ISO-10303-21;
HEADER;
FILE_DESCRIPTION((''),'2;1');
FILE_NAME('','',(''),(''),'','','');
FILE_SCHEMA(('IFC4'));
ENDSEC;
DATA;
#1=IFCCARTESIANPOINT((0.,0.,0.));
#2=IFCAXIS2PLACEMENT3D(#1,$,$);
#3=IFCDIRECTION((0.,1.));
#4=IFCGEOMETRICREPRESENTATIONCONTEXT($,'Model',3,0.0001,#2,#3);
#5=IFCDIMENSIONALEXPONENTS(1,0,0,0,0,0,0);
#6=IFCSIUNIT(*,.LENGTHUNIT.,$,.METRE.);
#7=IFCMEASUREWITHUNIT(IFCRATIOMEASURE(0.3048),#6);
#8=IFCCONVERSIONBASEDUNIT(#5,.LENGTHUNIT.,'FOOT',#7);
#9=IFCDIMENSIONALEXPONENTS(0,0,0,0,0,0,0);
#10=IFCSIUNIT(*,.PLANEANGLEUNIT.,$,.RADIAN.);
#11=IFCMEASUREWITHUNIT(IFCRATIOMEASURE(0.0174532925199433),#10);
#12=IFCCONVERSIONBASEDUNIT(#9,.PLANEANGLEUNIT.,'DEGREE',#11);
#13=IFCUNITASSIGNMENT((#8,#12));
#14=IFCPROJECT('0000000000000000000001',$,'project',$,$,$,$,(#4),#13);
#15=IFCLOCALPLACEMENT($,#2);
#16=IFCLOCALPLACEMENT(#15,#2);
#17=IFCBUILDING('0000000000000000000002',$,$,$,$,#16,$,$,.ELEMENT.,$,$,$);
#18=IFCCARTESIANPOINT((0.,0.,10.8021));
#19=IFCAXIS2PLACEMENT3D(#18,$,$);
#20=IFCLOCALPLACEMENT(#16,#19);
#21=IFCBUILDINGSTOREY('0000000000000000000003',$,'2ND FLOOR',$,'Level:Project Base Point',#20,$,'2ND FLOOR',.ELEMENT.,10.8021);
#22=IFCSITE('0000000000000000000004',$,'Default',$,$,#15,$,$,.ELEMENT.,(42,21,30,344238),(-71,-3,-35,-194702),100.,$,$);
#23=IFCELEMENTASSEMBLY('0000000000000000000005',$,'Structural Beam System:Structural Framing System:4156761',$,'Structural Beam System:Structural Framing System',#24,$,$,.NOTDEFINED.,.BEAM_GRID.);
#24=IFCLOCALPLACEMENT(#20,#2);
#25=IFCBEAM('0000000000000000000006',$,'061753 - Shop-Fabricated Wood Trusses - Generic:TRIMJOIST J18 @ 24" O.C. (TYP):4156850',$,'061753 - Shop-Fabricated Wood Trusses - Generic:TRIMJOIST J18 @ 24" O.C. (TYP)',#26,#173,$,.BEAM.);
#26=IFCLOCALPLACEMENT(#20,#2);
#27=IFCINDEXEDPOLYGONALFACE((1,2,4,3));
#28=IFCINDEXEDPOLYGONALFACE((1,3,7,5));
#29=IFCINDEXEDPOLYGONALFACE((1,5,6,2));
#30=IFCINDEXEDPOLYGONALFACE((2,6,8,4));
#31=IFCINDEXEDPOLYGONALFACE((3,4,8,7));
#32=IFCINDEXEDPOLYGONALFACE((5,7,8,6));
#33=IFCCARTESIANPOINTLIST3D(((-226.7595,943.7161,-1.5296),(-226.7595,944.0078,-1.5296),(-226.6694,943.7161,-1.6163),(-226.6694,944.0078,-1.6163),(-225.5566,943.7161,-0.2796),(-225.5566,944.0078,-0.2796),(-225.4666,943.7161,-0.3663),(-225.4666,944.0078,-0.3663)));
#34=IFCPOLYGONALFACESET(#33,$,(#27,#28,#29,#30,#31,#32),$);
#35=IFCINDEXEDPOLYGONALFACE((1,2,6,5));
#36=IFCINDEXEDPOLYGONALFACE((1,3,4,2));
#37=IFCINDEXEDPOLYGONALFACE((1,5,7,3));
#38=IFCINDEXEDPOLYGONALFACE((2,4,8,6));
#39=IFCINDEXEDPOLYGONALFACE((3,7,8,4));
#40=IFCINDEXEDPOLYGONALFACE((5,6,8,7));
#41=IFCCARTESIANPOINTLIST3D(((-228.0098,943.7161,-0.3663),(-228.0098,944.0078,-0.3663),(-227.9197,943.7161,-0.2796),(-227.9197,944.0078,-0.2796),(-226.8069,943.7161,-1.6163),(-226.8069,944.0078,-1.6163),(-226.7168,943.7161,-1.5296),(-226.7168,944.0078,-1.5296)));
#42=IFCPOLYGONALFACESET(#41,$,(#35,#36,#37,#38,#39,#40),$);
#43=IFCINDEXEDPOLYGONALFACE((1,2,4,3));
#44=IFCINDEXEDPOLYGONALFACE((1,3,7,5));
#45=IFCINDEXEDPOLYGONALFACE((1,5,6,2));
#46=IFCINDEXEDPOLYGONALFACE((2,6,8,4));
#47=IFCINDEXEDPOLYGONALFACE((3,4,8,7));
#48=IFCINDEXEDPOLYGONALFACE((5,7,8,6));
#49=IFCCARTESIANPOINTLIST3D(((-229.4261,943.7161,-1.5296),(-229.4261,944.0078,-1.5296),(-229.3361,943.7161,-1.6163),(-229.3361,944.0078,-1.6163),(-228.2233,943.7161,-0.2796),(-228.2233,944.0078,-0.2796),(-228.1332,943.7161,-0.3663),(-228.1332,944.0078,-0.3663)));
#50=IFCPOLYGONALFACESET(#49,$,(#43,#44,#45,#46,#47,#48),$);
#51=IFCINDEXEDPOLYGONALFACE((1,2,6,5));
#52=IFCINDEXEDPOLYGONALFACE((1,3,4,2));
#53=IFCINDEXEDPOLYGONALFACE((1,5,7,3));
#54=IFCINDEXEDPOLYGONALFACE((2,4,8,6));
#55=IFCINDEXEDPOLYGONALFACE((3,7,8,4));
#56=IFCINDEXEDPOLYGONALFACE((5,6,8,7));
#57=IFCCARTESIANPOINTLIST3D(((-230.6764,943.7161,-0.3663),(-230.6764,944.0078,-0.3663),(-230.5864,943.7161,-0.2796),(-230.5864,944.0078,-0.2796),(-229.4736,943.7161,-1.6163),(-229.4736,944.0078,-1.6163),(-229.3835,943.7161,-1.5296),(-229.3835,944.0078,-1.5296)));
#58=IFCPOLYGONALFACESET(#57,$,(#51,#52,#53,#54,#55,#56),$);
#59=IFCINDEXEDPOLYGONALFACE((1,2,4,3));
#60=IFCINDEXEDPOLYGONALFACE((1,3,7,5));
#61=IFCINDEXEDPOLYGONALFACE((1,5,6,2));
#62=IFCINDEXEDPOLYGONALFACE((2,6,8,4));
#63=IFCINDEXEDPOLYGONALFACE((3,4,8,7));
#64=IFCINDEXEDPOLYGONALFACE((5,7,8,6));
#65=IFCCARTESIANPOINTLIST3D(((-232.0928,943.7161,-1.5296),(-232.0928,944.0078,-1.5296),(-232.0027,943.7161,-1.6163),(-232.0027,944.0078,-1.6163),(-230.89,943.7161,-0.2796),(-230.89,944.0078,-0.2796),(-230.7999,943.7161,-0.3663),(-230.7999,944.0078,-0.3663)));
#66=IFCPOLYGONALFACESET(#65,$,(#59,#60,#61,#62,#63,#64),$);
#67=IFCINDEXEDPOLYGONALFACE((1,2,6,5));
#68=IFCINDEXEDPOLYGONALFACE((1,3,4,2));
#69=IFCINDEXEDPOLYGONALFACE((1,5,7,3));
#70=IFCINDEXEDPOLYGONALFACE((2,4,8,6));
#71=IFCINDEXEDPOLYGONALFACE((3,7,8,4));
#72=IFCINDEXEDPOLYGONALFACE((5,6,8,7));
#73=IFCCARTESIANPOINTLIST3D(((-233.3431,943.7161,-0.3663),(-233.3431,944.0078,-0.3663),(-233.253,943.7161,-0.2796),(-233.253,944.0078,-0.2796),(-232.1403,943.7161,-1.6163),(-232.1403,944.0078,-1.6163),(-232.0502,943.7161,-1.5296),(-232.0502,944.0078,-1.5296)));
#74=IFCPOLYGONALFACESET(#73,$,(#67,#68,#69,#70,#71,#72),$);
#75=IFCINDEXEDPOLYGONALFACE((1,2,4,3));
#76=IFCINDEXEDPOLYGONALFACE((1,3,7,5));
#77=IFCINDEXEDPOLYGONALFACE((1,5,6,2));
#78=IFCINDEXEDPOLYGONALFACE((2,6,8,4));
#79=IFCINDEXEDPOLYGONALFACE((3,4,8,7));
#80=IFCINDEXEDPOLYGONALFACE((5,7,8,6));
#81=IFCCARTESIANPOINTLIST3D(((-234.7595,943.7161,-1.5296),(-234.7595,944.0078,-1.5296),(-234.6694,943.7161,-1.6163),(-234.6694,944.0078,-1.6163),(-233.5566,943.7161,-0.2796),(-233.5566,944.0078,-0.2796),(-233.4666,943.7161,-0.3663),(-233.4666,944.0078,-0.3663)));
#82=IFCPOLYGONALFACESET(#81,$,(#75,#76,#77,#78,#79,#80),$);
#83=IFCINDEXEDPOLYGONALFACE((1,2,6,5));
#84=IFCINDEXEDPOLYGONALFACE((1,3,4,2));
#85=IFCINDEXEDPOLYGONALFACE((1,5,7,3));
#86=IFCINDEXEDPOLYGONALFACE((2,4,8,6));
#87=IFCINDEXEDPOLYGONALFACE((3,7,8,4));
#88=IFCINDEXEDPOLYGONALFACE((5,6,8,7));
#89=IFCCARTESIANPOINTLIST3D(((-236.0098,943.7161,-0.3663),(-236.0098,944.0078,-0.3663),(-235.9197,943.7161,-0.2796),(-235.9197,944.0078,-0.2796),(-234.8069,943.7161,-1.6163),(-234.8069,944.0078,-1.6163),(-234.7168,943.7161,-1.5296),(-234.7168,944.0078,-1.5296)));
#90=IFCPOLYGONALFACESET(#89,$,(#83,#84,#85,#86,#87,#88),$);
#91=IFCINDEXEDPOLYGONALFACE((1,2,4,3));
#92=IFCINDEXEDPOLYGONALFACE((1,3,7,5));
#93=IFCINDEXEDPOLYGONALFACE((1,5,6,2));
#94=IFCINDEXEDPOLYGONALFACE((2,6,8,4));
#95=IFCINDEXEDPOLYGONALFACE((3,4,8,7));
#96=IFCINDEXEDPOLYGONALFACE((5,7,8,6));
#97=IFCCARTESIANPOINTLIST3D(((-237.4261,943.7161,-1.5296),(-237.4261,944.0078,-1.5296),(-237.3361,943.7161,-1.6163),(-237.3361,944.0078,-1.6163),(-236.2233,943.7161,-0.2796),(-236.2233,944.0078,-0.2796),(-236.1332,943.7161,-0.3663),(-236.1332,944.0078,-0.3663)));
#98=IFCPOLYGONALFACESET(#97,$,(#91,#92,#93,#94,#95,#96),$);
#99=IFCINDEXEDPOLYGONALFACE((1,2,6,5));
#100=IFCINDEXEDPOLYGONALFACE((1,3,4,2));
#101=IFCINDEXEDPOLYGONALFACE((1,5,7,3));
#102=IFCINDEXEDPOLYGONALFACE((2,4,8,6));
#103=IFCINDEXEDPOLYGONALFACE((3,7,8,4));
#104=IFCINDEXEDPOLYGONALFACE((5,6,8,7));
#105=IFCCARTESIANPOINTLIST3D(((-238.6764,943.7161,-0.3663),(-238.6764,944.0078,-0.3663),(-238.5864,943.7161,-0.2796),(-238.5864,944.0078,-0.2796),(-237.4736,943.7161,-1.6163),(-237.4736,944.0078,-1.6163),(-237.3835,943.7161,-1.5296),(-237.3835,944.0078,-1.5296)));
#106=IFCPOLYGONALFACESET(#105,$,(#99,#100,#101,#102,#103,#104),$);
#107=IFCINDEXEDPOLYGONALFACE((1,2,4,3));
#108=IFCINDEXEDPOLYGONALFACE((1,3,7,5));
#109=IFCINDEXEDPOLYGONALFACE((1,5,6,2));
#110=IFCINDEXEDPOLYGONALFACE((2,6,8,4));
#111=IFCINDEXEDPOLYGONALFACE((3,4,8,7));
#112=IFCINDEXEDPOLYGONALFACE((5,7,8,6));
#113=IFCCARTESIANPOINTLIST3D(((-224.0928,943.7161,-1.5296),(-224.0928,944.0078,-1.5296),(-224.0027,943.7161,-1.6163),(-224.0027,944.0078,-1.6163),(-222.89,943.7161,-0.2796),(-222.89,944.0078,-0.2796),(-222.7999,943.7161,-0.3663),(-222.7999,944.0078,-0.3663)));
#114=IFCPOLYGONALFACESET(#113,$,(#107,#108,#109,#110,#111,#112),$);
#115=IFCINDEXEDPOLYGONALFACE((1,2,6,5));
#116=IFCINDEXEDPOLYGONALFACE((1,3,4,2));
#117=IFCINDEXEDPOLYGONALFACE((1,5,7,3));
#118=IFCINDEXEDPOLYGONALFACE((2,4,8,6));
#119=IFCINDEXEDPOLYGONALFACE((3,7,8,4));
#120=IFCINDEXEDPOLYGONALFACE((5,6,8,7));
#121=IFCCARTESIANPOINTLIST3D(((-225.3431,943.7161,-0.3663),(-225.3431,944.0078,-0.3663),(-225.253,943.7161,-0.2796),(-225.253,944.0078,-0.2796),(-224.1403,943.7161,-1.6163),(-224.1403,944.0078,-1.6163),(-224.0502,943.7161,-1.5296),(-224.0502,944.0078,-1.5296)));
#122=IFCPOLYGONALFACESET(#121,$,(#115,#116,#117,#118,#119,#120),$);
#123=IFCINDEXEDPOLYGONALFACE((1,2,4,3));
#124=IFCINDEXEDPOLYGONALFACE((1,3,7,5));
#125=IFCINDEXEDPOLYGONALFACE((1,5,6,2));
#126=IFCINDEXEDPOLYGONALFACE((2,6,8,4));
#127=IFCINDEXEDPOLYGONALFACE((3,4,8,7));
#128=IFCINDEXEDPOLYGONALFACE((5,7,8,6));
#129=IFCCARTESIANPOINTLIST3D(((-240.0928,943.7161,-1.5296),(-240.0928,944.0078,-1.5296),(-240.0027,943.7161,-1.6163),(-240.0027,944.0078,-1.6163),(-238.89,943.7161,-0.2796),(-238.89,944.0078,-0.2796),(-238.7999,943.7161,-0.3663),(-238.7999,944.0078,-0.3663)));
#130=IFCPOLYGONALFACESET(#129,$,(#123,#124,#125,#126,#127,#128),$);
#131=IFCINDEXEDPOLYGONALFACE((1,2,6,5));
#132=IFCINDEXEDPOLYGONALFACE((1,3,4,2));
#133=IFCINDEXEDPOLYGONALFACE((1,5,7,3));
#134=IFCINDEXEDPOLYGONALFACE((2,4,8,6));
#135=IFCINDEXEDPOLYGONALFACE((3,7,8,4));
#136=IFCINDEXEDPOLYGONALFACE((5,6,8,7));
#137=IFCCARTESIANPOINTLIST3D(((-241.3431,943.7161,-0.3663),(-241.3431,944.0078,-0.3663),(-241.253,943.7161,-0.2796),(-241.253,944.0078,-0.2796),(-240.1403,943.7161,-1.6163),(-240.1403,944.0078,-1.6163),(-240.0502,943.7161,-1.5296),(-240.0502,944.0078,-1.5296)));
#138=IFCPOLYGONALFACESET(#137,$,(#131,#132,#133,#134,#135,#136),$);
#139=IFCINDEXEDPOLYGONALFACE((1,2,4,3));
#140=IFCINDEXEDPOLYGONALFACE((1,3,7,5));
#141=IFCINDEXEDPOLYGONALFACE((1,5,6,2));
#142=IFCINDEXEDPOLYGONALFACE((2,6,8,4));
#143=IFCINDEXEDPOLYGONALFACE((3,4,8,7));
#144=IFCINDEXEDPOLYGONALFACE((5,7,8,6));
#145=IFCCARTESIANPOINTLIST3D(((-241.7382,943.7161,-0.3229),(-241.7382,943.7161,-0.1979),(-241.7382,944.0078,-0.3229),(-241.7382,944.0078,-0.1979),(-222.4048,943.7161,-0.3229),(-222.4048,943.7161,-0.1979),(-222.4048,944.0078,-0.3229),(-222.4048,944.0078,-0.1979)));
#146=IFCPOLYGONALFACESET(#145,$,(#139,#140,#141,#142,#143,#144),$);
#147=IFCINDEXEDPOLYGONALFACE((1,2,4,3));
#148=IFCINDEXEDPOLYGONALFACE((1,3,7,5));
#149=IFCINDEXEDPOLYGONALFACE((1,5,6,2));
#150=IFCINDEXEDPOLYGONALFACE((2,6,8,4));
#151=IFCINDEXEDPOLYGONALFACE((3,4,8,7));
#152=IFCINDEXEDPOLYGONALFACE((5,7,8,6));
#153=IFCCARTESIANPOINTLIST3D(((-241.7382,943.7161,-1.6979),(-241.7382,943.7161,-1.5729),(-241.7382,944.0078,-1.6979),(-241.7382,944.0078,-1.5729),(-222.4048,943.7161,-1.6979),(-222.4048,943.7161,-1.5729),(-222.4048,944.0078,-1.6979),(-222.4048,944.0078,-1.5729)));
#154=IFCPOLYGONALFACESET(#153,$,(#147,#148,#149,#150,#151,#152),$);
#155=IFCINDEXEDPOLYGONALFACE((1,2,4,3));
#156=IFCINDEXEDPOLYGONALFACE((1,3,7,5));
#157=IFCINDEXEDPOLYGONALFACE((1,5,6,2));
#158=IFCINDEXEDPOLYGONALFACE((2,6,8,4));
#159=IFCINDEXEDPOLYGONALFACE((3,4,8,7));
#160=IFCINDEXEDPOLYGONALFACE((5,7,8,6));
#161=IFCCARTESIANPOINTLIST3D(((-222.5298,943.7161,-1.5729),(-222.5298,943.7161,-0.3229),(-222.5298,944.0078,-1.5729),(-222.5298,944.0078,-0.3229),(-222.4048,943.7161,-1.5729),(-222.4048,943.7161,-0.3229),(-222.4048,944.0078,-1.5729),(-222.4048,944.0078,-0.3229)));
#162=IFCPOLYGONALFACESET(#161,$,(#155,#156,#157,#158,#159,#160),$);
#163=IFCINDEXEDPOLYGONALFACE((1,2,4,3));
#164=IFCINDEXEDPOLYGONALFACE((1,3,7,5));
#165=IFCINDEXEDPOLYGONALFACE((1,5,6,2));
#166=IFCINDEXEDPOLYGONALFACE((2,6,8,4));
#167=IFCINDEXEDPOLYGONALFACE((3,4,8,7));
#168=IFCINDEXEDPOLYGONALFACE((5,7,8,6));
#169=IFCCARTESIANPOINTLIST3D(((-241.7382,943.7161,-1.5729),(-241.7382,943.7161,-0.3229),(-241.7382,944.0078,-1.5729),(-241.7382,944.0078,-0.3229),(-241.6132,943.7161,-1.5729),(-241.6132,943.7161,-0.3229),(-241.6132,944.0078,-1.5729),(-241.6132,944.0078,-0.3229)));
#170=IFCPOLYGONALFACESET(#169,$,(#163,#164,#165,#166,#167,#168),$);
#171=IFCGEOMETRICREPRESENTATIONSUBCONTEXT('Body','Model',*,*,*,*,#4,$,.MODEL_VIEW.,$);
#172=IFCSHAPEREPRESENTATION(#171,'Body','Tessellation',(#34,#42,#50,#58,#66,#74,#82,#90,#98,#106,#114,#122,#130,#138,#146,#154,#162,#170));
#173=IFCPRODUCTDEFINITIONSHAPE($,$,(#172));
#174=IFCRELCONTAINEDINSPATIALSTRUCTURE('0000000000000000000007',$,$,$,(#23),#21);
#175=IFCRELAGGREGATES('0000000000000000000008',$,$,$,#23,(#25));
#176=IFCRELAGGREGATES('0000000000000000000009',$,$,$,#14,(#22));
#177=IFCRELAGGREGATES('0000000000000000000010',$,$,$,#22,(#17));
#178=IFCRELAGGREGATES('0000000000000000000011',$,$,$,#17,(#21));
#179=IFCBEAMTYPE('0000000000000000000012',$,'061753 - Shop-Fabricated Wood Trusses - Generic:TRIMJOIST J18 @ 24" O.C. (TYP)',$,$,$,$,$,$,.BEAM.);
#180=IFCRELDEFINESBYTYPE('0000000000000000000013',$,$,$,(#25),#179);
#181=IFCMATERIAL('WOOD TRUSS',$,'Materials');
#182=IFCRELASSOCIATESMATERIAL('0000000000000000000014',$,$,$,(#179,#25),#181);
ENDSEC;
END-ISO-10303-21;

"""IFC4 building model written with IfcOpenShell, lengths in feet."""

from ifc_helpers import new_model, entity, si_unit, converted_unit, direction, frame, frame_2d, origin, origin_2d_with_axis, place, context, subcontext, project, spatial, rectangle, extrude, source, transform, mapped, material, material_profile, profile_set, profile_usage, type_object, type_shapes, element, aggregate, save


model = new_model("IFC4")

# Units and contexts
model_context = context("Model", 3, precision=0.0001, world=origin(), true_north=direction((0.0, 1.0)))
body_context = subcontext(model_context, "Body", "Model", "MODEL_VIEW")
ifc_project = project(units=[converted_unit("LENGTHUNIT", "FOOT", entity("IfcRatioMeasure", 0.3048), si_unit("LENGTHUNIT", "METRE"), dimensions=[1, 0, 0, 0, 0, 0, 0]), converted_unit("PLANEANGLEUNIT", "DEGREE", entity("IfcRatioMeasure", 0.0174532925199433), si_unit("PLANEANGLEUNIT", "RADIAN"), dimensions=[0, 0, 0, 0, 0, 0, 0])], contexts=[model_context])

# Site, building, storey
site_placement = place(None, origin())
site = spatial("IfcSite", under=ifc_project, at=site_placement, Name="Default", CompositionType="ELEMENT", RefLatitude=(42, 21, 30, 344238), RefLongitude=(-71, -3, -35, -194702), RefElevation=100.0)
building_placement = place(site_placement, origin())
building = spatial("IfcBuilding", under=site, at=building_placement, CompositionType="ELEMENT")
storey_placement = place(building_placement, frame((0.0, 0.0, 10.8021)))
storey = spatial("IfcBuildingStorey", under=building, at=storey_placement, Name="2ND FLOOR", ObjectType="Level:Project Base Point", LongName="2ND FLOOR", CompositionType="ELEMENT", Elevation=10.8021)

# Element assembly, beam
assembly_1_placement = place(storey_placement, origin())
assembly_1 = element("IfcElementAssembly", 1, at=assembly_1_placement, inside=storey, Name="Structural Beam System:Structural Framing System:4156761", ObjectType="Structural Beam System:Structural Framing System", AssemblyPlace="NOTDEFINED", PredefinedType="BEAM_GRID")
ifc_material_1 = material(Name="WOOD TRUSS", Category="Materials")
ifc_material_profile_1 = material_profile(ifc_material_1, rectangle(XDim=1.7347, YDim=0.125, at=frame_2d((0.0, 0.0), x_axis=(1.0, 0.0))), Name="TRIMJOIST J18 @ 24\" O.C. (TYP)")
ifc_material_profile_2 = material_profile(ifc_material_1, rectangle(XDim=1.7347, YDim=0.125, at=frame_2d((0.0, 0.0), x_axis=(1.0, 0.0))), Name="TRIMJOIST J18 @ 24\" O.C. (TYP)")
ifc_material_profile_3 = material_profile(ifc_material_1, rectangle(XDim=1.7347, YDim=0.125, at=frame_2d((0.0, 0.0), x_axis=(1.0, 0.0))), Name="TRIMJOIST J18 @ 24\" O.C. (TYP)")
ifc_material_profile_4 = material_profile(ifc_material_1, rectangle(XDim=1.7347, YDim=0.125, at=frame_2d((0.0, 0.0), x_axis=(1.0, 0.0))), Name="TRIMJOIST J18 @ 24\" O.C. (TYP)")
ifc_material_profile_5 = material_profile(ifc_material_1, rectangle(XDim=1.7347, YDim=0.125, at=frame_2d((0.0, 0.0), x_axis=(1.0, 0.0))), Name="TRIMJOIST J18 @ 24\" O.C. (TYP)")
ifc_material_profile_6 = material_profile(ifc_material_1, rectangle(XDim=1.7347, YDim=0.125, at=frame_2d((0.0, 0.0), x_axis=(1.0, 0.0))), Name="TRIMJOIST J18 @ 24\" O.C. (TYP)")
ifc_material_profile_7 = material_profile(ifc_material_1, rectangle(XDim=1.7347, YDim=0.125, at=frame_2d((0.0, 0.0), x_axis=(1.0, 0.0))), Name="TRIMJOIST J18 @ 24\" O.C. (TYP)")
ifc_material_profile_8 = material_profile(ifc_material_1, rectangle(XDim=1.7347, YDim=0.125, at=frame_2d((0.0, 0.0), x_axis=(1.0, 0.0))), Name="TRIMJOIST J18 @ 24\" O.C. (TYP)")
ifc_material_profile_9 = material_profile(ifc_material_1, rectangle(XDim=1.7347, YDim=0.125, at=frame_2d((0.0, 0.0), x_axis=(1.0, 0.0))), Name="TRIMJOIST J18 @ 24\" O.C. (TYP)")
ifc_material_profile_10 = material_profile(ifc_material_1, rectangle(XDim=1.7347, YDim=0.125, at=origin_2d_with_axis()), Name="TRIMJOIST J18 @ 24\" O.C. (TYP)")
ifc_material_profile_11 = material_profile(ifc_material_1, rectangle(XDim=0.125, YDim=0.2917, at=origin_2d_with_axis()), Name="TRIMJOIST J18 @ 24\" O.C. (TYP)")
ifc_material_profile_12 = material_profile(ifc_material_1, rectangle(XDim=0.125, YDim=0.2917, at=origin_2d_with_axis()), Name="TRIMJOIST J18 @ 24\" O.C. (TYP)")
ifc_material_profile_13 = material_profile(ifc_material_1, rectangle(XDim=1.25, YDim=0.2917, at=origin_2d_with_axis()), Name="TRIMJOIST J18 @ 24\" O.C. (TYP)")
ifc_material_profile_14 = material_profile(ifc_material_1, rectangle(XDim=1.25, YDim=0.2917, at=origin_2d_with_axis()), Name="TRIMJOIST J18 @ 24\" O.C. (TYP)")
ifc_profile_set_1 = profile_set([ifc_material_profile_1, ifc_material_profile_2, ifc_material_profile_3, ifc_material_profile_4, ifc_material_profile_5, ifc_material_profile_6, ifc_material_profile_7, ifc_material_profile_8, ifc_material_profile_9, ifc_material_profile_10, ifc_material_profile_11, ifc_material_profile_12, ifc_material_profile_13, ifc_material_profile_14], Name="TRIMJOIST J18 @ 24\" O.C. (TYP)")
beam_type_1 = type_object("IfcBeamType", Name="061753 - Shop-Fabricated Wood Trusses - Generic:TRIMJOIST J18 @ 24\" O.C. (TYP)", PredefinedType="BEAM", material=ifc_profile_set_1)
shared_shape_1 = source(origin(), body_context, "Body", "SweptSolid", [
    extrude(rectangle(XDim=1.7347, YDim=0.125, at=frame_2d((0.0, 0.0), x_axis=(1.0, 0.0))), frame((5.9585, -0.1458, 0.0), z_axis=(0.0, 1.0, 0.0), x_axis=(0.693383, 0.0, 0.720569)), (0.0, 0.0, 1.0), 0.2917),
    extrude(rectangle(XDim=1.7347, YDim=0.125, at=origin_2d_with_axis()), frame((4.7082, -0.1458, 0.0), z_axis=(0.0, 1.0, 0.0), x_axis=(0.693383, 0.0, -0.720569)), (0.0, 0.0, 1.0), 0.2917),
    extrude(rectangle(XDim=1.7347, YDim=0.125, at=frame_2d((0.0, 0.0), x_axis=(1.0, 0.0))), frame((3.2918, -0.1458, 0.0), z_axis=(0.0, 1.0, 0.0), x_axis=(0.693383, 0.0, 0.720569)), (0.0, 0.0, 1.0), 0.2917),
    extrude(rectangle(XDim=1.7347, YDim=0.125, at=frame_2d((0.0, 0.0), x_axis=(1.0, 0.0))), frame((2.0415, -0.1458, 0.0), z_axis=(0.0, 1.0, 0.0), x_axis=(0.693383, 0.0, -0.720569)), (0.0, 0.0, 1.0), 0.2917),
    extrude(rectangle(XDim=1.7347, YDim=0.125, at=frame_2d((0.0, 0.0), x_axis=(1.0, 0.0))), frame((0.6251, -0.1458, 0.0), z_axis=(0.0, 1.0, 0.0), x_axis=(0.693383, 0.0, 0.720569)), (0.0, 0.0, 1.0), 0.2917),
    extrude(rectangle(XDim=1.7347, YDim=0.125, at=frame_2d((0.0, 0.0), x_axis=(1.0, 0.0))), frame((-0.6251, -0.1458, 0.0), z_axis=(0.0, 1.0, 0.0), x_axis=(0.693383, 0.0, -0.720569)), (0.0, 0.0, 1.0), 0.2917),
    extrude(rectangle(XDim=1.7347, YDim=0.125, at=frame_2d((0.0, 0.0), x_axis=(1.0, 0.0))), frame((-2.0415, -0.1458, 0.0), z_axis=(0.0, 1.0, 0.0), x_axis=(0.693383, 0.0, 0.720569)), (0.0, 0.0, 1.0), 0.2917),
    extrude(rectangle(XDim=1.7347, YDim=0.125, at=origin_2d_with_axis()), frame((-3.2918, -0.1458, 0.0), z_axis=(0.0, 1.0, 0.0), x_axis=(0.693383, 0.0, -0.720569)), (0.0, 0.0, 1.0), 0.2917),
    extrude(rectangle(XDim=1.7347, YDim=0.125, at=frame_2d((0.0, 0.0), x_axis=(1.0, 0.0))), frame((-4.7082, -0.1458, 0.0), z_axis=(0.0, 1.0, 0.0), x_axis=(0.693383, 0.0, 0.720569)), (0.0, 0.0, 1.0), 0.2917),
    extrude(rectangle(XDim=1.7347, YDim=0.125, at=frame_2d((0.0, 0.0), x_axis=(1.0, 0.0))), frame((-5.9585, -0.1458, 0.0), z_axis=(0.0, 1.0, 0.0), x_axis=(0.693383, 0.0, -0.720569)), (0.0, 0.0, 1.0), 0.2917),
    extrude(rectangle(XDim=1.7347, YDim=0.125, at=frame_2d((0.0, 0.0), x_axis=(1.0, 0.0))), frame((8.6251, -0.1458, 0.0), z_axis=(0.0, 1.0, 0.0), x_axis=(0.693383, 0.0, 0.720569)), (0.0, 0.0, 1.0), 0.2917),
    extrude(rectangle(XDim=1.7347, YDim=0.125, at=origin_2d_with_axis()), frame((7.3749, -0.1458, 0.0), z_axis=(0.0, 1.0, 0.0), x_axis=(0.693383, 0.0, -0.720569)), (0.0, 0.0, 1.0), 0.2917),
    extrude(rectangle(XDim=1.7347, YDim=0.125, at=frame_2d((0.0, 0.0), x_axis=(1.0, 0.0))), frame((-7.3749, -0.1458, 0.0), z_axis=(0.0, 1.0, 0.0), x_axis=(0.693383, 0.0, 0.720569)), (0.0, 0.0, 1.0), 0.2917),
    extrude(rectangle(XDim=1.7347, YDim=0.125, at=origin_2d_with_axis()), frame((-8.6251, -0.1458, 0.0), z_axis=(0.0, 1.0, 0.0), x_axis=(0.693383, 0.0, -0.720569)), (0.0, 0.0, 1.0), 0.2917),
    extrude(rectangle(XDim=0.125, YDim=0.2917, at=origin_2d_with_axis()), frame((-9.6667, 0.0, 0.6875), z_axis=(1.0, 0.0, 0.0), x_axis=(0.0, 0.0, -1.0)), (0.0, 0.0, 1.0), 19.3333),
    extrude(rectangle(XDim=0.125, YDim=0.2917, at=origin_2d_with_axis()), frame((-9.6667, 0.0, -0.6875), z_axis=(1.0, 0.0, 0.0), x_axis=(0.0, 0.0, -1.0)), (0.0, 0.0, 1.0), 19.3333),
    extrude(rectangle(XDim=1.25, YDim=0.2917, at=origin_2d_with_axis()), frame((9.5417, 0.0, 0.0), z_axis=(1.0, 0.0, 0.0), x_axis=(0.0, 0.0, -1.0)), (0.0, 0.0, 1.0), 0.125),
    extrude(rectangle(XDim=1.25, YDim=0.2917, at=origin_2d_with_axis()), frame((-9.6667, 0.0, 0.0), z_axis=(1.0, 0.0, 0.0), x_axis=(0.0, 0.0, -1.0)), (0.0, 0.0, 1.0), 0.125),
])
type_shapes(beam_type_1, [shared_shape_1])
ifc_profile_usage_1 = profile_usage(ifc_profile_set_1, cardinal=8)
beam_1_placement = place(assembly_1_placement, frame((-232.0715, 943.8619, -0.9479)))
beam_1 = element("IfcBeam", 2, at=beam_1_placement, type_object=beam_type_1, material=ifc_profile_usage_1, Name="061753 - Shop-Fabricated Wood Trusses - Generic:TRIMJOIST J18 @ 24\" O.C. (TYP):4156850", ObjectType="061753 - Shop-Fabricated Wood Trusses - Generic:TRIMJOIST J18 @ 24\" O.C. (TYP)", PredefinedType="BEAM", context=body_context, shape_type="MappedRepresentation", body=[
    mapped(shared_shape_1, transform((0.0, 0.0, 0.0), scale=1.0)),
])
aggregate(assembly_1, [beam_1])

save(model, "model.ifc")
